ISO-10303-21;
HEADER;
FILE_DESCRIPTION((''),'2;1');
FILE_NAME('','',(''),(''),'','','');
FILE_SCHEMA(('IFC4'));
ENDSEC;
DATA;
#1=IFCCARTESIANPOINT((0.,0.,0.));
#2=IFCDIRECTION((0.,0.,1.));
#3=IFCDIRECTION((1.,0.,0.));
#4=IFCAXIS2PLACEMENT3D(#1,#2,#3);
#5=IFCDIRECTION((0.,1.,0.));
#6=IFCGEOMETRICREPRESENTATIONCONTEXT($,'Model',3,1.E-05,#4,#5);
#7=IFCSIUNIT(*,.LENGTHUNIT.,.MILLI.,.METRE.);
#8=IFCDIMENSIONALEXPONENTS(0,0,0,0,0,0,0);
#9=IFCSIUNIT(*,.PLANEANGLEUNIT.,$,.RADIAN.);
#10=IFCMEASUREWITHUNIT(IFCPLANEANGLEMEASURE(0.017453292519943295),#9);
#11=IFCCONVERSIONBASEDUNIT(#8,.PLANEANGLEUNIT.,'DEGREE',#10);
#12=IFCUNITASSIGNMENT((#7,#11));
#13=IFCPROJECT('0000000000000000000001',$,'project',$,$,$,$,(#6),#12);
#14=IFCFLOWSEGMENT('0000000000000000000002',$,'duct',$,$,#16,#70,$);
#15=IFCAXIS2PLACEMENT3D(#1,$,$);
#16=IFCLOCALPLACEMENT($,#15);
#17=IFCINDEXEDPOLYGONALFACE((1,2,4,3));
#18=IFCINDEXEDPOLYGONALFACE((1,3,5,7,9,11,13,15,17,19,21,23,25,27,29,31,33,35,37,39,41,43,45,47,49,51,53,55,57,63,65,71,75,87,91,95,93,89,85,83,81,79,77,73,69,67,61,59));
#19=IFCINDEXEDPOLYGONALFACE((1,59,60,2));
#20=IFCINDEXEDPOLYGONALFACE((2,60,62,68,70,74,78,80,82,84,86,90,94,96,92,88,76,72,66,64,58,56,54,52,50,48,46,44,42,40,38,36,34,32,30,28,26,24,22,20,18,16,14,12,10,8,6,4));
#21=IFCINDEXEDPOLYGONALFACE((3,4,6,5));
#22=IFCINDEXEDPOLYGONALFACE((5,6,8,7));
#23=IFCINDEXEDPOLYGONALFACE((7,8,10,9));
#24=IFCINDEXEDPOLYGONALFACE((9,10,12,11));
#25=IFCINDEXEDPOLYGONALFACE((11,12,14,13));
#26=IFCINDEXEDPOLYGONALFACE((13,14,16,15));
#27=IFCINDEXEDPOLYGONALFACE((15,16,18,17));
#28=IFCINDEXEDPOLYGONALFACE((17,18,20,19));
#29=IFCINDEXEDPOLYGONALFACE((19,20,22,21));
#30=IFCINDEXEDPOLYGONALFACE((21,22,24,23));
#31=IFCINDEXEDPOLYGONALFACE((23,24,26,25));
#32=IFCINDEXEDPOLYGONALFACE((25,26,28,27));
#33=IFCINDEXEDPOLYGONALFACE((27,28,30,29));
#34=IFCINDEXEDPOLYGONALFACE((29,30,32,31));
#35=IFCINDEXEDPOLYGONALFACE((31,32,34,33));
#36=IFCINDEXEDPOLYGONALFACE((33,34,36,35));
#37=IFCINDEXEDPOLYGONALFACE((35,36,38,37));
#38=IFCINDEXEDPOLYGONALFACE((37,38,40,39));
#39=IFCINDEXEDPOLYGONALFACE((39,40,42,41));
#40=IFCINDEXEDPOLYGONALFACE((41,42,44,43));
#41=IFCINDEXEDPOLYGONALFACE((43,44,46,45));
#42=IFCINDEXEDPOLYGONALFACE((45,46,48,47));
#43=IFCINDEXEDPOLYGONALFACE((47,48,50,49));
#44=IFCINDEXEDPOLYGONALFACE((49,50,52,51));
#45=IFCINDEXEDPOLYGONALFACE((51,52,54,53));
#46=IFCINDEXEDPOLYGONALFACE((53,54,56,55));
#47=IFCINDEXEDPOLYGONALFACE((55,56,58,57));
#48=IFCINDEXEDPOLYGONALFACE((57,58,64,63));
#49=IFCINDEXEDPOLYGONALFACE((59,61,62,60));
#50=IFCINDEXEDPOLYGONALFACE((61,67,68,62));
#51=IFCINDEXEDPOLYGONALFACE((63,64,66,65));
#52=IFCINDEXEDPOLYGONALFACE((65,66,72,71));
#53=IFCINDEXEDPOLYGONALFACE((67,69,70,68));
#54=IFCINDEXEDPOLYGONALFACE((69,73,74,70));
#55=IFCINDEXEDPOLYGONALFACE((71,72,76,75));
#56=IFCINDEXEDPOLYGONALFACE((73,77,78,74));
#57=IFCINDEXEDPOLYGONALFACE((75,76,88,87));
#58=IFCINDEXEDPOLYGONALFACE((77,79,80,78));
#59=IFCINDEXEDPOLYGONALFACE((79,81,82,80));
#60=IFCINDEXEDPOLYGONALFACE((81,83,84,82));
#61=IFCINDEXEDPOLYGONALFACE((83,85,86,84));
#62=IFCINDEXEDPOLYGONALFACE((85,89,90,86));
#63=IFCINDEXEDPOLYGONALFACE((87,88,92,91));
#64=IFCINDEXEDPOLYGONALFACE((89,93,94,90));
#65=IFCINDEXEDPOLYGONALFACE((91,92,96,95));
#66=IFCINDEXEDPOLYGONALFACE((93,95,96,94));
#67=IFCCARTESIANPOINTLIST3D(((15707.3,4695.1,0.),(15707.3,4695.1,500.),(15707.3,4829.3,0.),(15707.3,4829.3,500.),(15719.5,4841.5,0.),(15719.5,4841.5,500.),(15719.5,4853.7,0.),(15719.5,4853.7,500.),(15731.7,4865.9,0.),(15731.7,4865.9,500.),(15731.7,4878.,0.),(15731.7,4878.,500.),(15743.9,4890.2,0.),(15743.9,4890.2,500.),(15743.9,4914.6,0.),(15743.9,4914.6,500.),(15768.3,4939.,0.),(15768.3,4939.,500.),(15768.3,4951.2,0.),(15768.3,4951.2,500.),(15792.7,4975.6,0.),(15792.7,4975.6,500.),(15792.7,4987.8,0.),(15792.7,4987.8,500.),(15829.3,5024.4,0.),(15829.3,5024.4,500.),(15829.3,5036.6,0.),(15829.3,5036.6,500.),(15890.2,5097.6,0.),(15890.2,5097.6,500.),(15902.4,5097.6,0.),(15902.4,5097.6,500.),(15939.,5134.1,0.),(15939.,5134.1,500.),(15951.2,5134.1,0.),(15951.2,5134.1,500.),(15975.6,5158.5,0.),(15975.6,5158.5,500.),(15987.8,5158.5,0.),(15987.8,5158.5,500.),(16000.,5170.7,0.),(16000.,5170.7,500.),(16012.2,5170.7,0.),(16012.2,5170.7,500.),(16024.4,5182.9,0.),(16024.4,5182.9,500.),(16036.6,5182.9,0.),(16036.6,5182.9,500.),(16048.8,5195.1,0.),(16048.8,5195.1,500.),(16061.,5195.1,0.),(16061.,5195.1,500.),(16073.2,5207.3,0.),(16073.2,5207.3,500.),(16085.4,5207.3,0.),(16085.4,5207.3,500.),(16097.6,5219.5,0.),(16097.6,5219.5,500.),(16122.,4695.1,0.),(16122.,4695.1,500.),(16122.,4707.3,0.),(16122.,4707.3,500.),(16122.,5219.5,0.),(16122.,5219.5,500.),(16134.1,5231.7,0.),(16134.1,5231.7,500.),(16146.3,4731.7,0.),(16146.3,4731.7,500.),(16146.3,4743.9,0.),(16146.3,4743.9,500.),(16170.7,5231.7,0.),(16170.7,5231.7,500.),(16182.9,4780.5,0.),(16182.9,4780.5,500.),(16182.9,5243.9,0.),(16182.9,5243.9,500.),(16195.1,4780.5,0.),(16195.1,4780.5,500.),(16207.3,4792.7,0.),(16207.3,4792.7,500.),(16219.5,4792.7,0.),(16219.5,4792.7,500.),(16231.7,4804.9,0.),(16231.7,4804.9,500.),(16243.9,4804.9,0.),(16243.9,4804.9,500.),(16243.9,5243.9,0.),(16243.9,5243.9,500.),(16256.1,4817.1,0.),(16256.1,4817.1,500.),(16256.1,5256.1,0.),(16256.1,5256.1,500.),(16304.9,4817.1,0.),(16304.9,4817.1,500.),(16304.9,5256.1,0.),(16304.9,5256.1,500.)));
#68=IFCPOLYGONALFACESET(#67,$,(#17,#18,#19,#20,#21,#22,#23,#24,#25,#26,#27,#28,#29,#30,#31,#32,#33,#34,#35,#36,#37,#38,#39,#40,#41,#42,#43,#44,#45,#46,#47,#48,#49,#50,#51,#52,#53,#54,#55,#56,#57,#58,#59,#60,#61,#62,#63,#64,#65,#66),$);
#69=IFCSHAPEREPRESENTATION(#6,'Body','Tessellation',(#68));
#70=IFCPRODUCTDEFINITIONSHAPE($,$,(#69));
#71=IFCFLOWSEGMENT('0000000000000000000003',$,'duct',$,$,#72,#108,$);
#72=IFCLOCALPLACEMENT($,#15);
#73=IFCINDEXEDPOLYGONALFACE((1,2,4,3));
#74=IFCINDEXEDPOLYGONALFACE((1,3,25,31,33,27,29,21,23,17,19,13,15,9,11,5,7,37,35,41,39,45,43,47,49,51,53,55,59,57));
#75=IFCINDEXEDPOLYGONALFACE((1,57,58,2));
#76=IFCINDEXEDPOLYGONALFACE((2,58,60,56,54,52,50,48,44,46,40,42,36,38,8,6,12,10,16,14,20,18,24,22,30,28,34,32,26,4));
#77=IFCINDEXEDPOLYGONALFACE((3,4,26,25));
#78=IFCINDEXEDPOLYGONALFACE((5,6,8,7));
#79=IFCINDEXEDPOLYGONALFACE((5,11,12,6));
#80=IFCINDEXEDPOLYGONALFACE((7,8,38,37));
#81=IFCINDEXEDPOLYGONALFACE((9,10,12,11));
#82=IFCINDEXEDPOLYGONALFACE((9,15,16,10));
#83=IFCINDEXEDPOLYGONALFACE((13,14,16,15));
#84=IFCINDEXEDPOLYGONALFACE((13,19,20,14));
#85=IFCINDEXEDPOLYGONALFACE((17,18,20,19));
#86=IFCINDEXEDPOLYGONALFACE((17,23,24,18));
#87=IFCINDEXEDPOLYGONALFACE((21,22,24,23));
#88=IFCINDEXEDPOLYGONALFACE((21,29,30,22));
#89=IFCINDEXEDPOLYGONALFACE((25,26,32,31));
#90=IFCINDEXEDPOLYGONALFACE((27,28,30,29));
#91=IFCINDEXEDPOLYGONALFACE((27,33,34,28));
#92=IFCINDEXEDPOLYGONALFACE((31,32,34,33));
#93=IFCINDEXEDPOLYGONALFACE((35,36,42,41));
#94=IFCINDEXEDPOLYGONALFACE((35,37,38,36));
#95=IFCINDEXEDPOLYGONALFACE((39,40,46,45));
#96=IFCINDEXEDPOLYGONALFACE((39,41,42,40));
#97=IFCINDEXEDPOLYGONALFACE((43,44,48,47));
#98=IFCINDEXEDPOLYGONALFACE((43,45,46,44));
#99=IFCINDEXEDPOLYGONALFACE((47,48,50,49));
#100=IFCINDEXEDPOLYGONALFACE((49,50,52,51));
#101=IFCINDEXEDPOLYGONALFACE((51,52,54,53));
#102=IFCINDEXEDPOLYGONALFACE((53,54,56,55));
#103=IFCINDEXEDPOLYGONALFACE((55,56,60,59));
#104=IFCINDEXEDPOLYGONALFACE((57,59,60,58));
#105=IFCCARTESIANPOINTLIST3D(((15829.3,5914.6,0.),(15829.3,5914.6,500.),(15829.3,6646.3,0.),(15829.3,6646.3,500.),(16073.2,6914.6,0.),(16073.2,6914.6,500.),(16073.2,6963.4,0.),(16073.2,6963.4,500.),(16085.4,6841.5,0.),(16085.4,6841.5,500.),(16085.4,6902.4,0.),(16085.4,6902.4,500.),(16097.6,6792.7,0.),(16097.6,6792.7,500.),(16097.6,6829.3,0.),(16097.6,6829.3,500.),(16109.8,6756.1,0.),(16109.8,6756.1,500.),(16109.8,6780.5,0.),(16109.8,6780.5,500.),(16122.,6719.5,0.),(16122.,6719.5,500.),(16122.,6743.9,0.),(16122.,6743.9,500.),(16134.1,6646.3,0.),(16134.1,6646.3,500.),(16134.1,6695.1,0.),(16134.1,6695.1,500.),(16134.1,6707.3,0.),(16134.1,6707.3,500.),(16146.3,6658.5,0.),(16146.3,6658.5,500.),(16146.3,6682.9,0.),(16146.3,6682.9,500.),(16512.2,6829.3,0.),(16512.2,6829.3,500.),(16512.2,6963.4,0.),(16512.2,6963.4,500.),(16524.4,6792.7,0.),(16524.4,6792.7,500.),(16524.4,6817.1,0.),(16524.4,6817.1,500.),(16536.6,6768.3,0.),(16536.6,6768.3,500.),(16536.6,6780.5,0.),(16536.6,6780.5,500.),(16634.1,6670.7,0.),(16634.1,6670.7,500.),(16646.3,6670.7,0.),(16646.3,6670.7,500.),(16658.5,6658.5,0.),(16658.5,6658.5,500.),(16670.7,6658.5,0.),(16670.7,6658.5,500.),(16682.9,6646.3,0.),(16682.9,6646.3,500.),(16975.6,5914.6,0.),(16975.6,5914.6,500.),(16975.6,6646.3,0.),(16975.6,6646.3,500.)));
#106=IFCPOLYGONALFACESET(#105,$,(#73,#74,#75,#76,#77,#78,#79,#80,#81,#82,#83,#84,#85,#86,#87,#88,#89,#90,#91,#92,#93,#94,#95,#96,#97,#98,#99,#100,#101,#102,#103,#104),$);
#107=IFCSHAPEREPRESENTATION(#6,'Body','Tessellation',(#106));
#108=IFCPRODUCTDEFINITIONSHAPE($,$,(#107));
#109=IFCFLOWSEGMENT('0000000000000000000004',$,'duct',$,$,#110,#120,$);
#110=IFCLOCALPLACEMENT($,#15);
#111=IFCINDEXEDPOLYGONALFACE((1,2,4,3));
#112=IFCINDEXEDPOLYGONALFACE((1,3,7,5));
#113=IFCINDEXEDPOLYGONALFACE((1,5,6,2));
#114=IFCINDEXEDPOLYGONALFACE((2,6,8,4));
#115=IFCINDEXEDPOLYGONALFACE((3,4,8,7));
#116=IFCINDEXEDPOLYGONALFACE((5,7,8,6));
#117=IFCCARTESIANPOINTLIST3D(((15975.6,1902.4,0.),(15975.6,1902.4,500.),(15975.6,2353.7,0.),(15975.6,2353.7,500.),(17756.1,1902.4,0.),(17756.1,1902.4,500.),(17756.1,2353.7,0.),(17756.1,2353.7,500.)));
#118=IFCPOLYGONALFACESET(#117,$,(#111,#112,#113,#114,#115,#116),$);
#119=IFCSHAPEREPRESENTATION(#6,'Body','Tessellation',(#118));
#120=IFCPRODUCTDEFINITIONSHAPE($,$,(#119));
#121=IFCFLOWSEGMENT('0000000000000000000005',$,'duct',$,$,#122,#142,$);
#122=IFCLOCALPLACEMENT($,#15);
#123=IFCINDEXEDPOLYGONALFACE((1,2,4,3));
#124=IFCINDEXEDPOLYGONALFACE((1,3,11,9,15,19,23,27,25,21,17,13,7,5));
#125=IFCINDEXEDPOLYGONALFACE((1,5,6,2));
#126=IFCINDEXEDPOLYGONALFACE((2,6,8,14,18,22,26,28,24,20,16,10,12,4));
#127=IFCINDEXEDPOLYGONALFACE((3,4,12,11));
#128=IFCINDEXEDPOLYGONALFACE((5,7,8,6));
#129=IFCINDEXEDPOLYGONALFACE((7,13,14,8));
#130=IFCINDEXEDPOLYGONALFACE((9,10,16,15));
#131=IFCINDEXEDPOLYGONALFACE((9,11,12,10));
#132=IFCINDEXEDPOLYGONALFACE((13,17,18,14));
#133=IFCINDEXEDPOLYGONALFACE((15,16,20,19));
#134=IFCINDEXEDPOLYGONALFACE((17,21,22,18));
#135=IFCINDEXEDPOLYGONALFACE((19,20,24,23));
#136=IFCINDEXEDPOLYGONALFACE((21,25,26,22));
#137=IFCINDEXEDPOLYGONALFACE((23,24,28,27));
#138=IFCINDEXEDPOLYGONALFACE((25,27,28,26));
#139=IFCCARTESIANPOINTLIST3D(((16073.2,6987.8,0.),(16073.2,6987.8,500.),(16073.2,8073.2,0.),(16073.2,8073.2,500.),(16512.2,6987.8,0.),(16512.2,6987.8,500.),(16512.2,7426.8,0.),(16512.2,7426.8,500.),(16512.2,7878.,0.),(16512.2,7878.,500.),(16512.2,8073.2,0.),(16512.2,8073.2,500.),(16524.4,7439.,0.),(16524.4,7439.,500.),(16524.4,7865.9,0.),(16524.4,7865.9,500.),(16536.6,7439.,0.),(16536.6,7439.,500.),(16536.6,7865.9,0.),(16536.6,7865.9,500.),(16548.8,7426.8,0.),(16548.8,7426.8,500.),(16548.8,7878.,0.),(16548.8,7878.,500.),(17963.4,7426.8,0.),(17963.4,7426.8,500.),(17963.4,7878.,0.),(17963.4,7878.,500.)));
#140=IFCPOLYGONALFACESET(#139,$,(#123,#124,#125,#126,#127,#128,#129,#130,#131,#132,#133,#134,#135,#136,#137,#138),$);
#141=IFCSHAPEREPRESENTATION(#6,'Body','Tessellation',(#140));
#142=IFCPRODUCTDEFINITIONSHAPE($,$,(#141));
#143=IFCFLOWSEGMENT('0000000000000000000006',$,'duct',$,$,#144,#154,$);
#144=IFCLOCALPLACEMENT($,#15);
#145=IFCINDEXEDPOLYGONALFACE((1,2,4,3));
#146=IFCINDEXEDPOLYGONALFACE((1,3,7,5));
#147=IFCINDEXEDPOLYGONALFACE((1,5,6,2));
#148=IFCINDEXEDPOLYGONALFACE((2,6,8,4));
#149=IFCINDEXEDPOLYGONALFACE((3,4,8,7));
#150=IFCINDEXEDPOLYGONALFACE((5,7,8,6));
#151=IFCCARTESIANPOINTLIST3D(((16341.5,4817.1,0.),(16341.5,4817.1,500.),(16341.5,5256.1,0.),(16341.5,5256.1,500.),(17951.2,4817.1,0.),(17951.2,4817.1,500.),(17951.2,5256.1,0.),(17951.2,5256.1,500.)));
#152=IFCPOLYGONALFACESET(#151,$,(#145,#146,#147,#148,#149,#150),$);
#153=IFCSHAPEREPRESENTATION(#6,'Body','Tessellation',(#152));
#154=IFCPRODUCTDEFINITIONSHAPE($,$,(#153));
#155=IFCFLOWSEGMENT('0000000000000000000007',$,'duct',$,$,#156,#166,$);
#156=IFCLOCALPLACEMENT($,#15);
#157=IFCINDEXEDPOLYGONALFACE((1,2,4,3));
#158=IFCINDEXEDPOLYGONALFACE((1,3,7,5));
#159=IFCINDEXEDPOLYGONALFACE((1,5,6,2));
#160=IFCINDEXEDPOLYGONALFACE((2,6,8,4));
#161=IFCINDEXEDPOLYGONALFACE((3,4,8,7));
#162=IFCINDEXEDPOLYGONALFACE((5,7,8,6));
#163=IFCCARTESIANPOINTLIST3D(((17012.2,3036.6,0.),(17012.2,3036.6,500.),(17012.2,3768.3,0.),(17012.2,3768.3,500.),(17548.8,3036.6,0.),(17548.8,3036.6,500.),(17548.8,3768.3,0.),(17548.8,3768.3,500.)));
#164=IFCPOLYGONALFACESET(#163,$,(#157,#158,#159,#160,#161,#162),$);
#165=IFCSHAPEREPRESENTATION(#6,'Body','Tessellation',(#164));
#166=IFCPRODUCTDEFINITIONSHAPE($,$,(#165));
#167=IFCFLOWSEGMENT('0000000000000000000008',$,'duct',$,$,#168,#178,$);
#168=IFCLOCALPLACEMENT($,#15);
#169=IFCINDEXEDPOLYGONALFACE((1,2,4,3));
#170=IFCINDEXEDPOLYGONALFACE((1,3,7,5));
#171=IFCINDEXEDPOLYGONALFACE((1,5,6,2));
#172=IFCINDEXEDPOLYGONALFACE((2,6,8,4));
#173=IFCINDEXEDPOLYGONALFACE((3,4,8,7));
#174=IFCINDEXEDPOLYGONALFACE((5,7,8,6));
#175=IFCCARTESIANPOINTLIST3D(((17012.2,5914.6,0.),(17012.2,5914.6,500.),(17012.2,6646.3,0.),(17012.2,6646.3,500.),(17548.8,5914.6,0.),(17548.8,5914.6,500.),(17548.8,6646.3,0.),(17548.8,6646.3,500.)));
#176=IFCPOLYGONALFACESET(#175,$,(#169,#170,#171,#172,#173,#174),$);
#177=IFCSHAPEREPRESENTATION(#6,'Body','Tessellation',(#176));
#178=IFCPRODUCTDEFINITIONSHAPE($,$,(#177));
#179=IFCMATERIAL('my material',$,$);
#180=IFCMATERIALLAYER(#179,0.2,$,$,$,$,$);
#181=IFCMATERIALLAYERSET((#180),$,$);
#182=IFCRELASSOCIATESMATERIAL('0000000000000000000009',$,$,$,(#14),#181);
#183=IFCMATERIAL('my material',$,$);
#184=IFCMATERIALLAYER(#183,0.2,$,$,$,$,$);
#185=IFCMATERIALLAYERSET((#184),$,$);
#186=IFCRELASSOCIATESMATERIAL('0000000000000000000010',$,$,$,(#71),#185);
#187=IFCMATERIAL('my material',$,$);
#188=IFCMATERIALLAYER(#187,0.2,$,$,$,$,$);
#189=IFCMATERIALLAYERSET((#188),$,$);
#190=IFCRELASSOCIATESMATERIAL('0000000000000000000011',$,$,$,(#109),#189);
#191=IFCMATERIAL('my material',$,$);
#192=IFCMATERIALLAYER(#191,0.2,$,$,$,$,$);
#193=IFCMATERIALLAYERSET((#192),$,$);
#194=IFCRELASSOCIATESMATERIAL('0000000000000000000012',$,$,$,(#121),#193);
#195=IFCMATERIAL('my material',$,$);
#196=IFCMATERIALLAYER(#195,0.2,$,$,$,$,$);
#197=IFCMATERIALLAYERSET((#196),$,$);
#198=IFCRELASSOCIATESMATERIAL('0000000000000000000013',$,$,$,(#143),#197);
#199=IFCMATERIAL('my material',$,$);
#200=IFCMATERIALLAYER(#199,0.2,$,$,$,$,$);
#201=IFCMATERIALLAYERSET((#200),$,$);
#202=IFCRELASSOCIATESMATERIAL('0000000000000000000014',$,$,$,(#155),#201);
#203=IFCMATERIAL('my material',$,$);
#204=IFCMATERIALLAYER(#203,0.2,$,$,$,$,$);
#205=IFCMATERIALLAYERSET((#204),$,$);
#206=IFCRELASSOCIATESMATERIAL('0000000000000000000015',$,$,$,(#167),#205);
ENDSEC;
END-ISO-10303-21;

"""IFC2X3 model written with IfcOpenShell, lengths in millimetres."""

from ifc_helpers import new_model, entity, si_unit, converted_unit, direction, origin_with_axes, place, context, project, polyline, outline, extrude, material, layer, layer_set, layer_usage, element, save


model = new_model("IFC2X3")

# Units and contexts
model_context = context("Model", 3, precision=1e-05, world=origin_with_axes(), true_north=direction((0.0, 1.0, 0.0)))
ifc_project = project(units=[si_unit("LENGTHUNIT", "METRE", prefix="MILLI"), converted_unit("PLANEANGLEUNIT", "DEGREE", entity("IfcPlaneAngleMeasure", 0.017453292519943295), si_unit("PLANEANGLEUNIT", "RADIAN"), dimensions=[0, 0, 0, 0, 0, 0, 0])], contexts=[model_context])

# Flow segments
ifc_material_1 = material(Name="my material")
ifc_layer_1 = layer(ifc_material_1, 0.2)
ifc_layer_set_1 = layer_set([ifc_layer_1])
ifc_layer_usage_1 = layer_usage(ifc_layer_set_1, "AXIS2", "POSITIVE", -0.1)
flow_segment_1_placement = place(None, origin_with_axes())
element("IfcFlowSegment", 1, at=flow_segment_1_placement, material=ifc_layer_usage_1, Name="duct", context=model_context, shape_type="SweptSolid", body=[
    extrude(outline(polyline([(15707.3, 4695.1), (16122.0, 4695.1), (16122.0, 4707.3), (16146.3, 4731.7), (16146.3, 4743.9), (16182.9, 4780.5), (16195.1, 4780.5), (16207.3, 4792.7), (16219.5, 4792.7), (16231.7, 4804.9), (16243.9, 4804.9), (16256.1, 4817.1), (16304.9, 4817.1), (16304.9, 5256.1), (16256.1, 5256.1), (16243.9, 5243.9), (16182.9, 5243.9), (16170.7, 5231.7), (16134.1, 5231.7), (16122.0, 5219.5), (16097.6, 5219.5), (16085.4, 5207.3), (16073.2, 5207.3), (16061.0, 5195.1), (16048.8, 5195.1), (16036.6, 5182.9), (16024.4, 5182.9), (16012.2, 5170.7), (16000.0, 5170.7), (15987.8, 5158.5), (15975.6, 5158.5), (15951.2, 5134.1), (15939.0, 5134.1), (15902.4, 5097.6), (15890.2, 5097.6), (15829.3, 5036.6), (15829.3, 5024.4), (15792.7, 4987.8), (15792.7, 4975.6), (15768.3, 4951.2), (15768.3, 4939.0), (15743.9, 4914.6), (15743.9, 4890.2), (15731.7, 4878.0), (15731.7, 4865.9), (15719.5, 4853.7), (15719.5, 4841.5), (15707.3, 4829.3), (15707.3, 4695.1)])), origin_with_axes(), (0.0, 0.0, 1.0), 500.0),
])
ifc_material_2 = material(Name="my material")
ifc_layer_2 = layer(ifc_material_2, 0.2)
ifc_layer_set_2 = layer_set([ifc_layer_2])
ifc_layer_usage_2 = layer_usage(ifc_layer_set_2, "AXIS2", "POSITIVE", -0.1)
flow_segment_2_placement = place(None, origin_with_axes())
element("IfcFlowSegment", 2, at=flow_segment_2_placement, material=ifc_layer_usage_2, Name="duct", context=model_context, shape_type="SweptSolid", body=[
    extrude(outline(polyline([(15829.3, 5914.6), (16975.6, 5914.6), (16975.6, 6646.3), (16682.9, 6646.3), (16670.7, 6658.5), (16658.5, 6658.5), (16646.3, 6670.7), (16634.1, 6670.7), (16536.6, 6768.3), (16536.6, 6780.5), (16524.4, 6792.7), (16524.4, 6817.1), (16512.2, 6829.3), (16512.2, 6963.4), (16073.2, 6963.4), (16073.2, 6914.6), (16085.4, 6902.4), (16085.4, 6841.5), (16097.6, 6829.3), (16097.6, 6792.7), (16109.8, 6780.5), (16109.8, 6756.1), (16122.0, 6743.9), (16122.0, 6719.5), (16134.1, 6707.3), (16134.1, 6695.1), (16146.3, 6682.9), (16146.3, 6658.5), (16134.1, 6646.3), (15829.3, 6646.3), (15829.3, 5914.6)])), origin_with_axes(), (0.0, 0.0, 1.0), 500.0),
])
ifc_material_3 = material(Name="my material")
ifc_layer_3 = layer(ifc_material_3, 0.2)
ifc_layer_set_3 = layer_set([ifc_layer_3])
ifc_layer_usage_3 = layer_usage(ifc_layer_set_3, "AXIS2", "POSITIVE", -0.1)
flow_segment_3_placement = place(None, origin_with_axes())
element("IfcFlowSegment", 3, at=flow_segment_3_placement, material=ifc_layer_usage_3, Name="duct", context=model_context, shape_type="SweptSolid", body=[
    extrude(outline(polyline([(15975.6, 1902.4), (17756.1, 1902.4), (17756.1, 2353.7), (15975.6, 2353.7), (15975.6, 1902.4)])), origin_with_axes(), (0.0, 0.0, 1.0), 500.0),
])
ifc_material_4 = material(Name="my material")
ifc_layer_4 = layer(ifc_material_4, 0.2)
ifc_layer_set_4 = layer_set([ifc_layer_4])
ifc_layer_usage_4 = layer_usage(ifc_layer_set_4, "AXIS2", "POSITIVE", -0.1)
flow_segment_4_placement = place(None, origin_with_axes())
element("IfcFlowSegment", 4, at=flow_segment_4_placement, material=ifc_layer_usage_4, Name="duct", context=model_context, shape_type="SweptSolid", body=[
    extrude(outline(polyline([(16073.2, 6987.8), (16512.2, 6987.8), (16512.2, 7426.8), (16524.4, 7439.0), (16536.6, 7439.0), (16548.8, 7426.8), (17963.4, 7426.8), (17963.4, 7878.0), (16548.8, 7878.0), (16536.6, 7865.9), (16524.4, 7865.9), (16512.2, 7878.0), (16512.2, 8073.2), (16073.2, 8073.2), (16073.2, 6987.8)])), origin_with_axes(), (0.0, 0.0, 1.0), 500.0),
])
ifc_material_5 = material(Name="my material")
ifc_layer_5 = layer(ifc_material_5, 0.2)
ifc_layer_set_5 = layer_set([ifc_layer_5])
ifc_layer_usage_5 = layer_usage(ifc_layer_set_5, "AXIS2", "POSITIVE", -0.1)
flow_segment_5_placement = place(None, origin_with_axes())
element("IfcFlowSegment", 5, at=flow_segment_5_placement, material=ifc_layer_usage_5, Name="duct", context=model_context, shape_type="SweptSolid", body=[
    extrude(outline(polyline([(16341.5, 4817.1), (17951.2, 4817.1), (17951.2, 5256.1), (16341.5, 5256.1), (16341.5, 4817.1)])), origin_with_axes(), (0.0, 0.0, 1.0), 500.0),
])
ifc_material_6 = material(Name="my material")
ifc_layer_6 = layer(ifc_material_6, 0.2)
ifc_layer_set_6 = layer_set([ifc_layer_6])
ifc_layer_usage_6 = layer_usage(ifc_layer_set_6, "AXIS2", "POSITIVE", -0.1)
flow_segment_6_placement = place(None, origin_with_axes())
element("IfcFlowSegment", 6, at=flow_segment_6_placement, material=ifc_layer_usage_6, Name="duct", context=model_context, shape_type="SweptSolid", body=[
    extrude(outline(polyline([(17012.2, 3036.6), (17548.8, 3036.6), (17548.8, 3768.3), (17012.2, 3768.3), (17012.2, 3036.6)])), origin_with_axes(), (0.0, 0.0, 1.0), 500.0),
])
ifc_material_7 = material(Name="my material")
ifc_layer_7 = layer(ifc_material_7, 0.2)
ifc_layer_set_7 = layer_set([ifc_layer_7])
ifc_layer_usage_7 = layer_usage(ifc_layer_set_7, "AXIS2", "POSITIVE", -0.1)
flow_segment_7_placement = place(None, origin_with_axes())
element("IfcFlowSegment", 7, at=flow_segment_7_placement, material=ifc_layer_usage_7, Name="duct", context=model_context, shape_type="SweptSolid", body=[
    extrude(outline(polyline([(17012.2, 5914.6), (17548.8, 5914.6), (17548.8, 6646.3), (17012.2, 6646.3), (17012.2, 5914.6)])), origin_with_axes(), (0.0, 0.0, 1.0), 500.0),
])

save(model, "model.ifc")
